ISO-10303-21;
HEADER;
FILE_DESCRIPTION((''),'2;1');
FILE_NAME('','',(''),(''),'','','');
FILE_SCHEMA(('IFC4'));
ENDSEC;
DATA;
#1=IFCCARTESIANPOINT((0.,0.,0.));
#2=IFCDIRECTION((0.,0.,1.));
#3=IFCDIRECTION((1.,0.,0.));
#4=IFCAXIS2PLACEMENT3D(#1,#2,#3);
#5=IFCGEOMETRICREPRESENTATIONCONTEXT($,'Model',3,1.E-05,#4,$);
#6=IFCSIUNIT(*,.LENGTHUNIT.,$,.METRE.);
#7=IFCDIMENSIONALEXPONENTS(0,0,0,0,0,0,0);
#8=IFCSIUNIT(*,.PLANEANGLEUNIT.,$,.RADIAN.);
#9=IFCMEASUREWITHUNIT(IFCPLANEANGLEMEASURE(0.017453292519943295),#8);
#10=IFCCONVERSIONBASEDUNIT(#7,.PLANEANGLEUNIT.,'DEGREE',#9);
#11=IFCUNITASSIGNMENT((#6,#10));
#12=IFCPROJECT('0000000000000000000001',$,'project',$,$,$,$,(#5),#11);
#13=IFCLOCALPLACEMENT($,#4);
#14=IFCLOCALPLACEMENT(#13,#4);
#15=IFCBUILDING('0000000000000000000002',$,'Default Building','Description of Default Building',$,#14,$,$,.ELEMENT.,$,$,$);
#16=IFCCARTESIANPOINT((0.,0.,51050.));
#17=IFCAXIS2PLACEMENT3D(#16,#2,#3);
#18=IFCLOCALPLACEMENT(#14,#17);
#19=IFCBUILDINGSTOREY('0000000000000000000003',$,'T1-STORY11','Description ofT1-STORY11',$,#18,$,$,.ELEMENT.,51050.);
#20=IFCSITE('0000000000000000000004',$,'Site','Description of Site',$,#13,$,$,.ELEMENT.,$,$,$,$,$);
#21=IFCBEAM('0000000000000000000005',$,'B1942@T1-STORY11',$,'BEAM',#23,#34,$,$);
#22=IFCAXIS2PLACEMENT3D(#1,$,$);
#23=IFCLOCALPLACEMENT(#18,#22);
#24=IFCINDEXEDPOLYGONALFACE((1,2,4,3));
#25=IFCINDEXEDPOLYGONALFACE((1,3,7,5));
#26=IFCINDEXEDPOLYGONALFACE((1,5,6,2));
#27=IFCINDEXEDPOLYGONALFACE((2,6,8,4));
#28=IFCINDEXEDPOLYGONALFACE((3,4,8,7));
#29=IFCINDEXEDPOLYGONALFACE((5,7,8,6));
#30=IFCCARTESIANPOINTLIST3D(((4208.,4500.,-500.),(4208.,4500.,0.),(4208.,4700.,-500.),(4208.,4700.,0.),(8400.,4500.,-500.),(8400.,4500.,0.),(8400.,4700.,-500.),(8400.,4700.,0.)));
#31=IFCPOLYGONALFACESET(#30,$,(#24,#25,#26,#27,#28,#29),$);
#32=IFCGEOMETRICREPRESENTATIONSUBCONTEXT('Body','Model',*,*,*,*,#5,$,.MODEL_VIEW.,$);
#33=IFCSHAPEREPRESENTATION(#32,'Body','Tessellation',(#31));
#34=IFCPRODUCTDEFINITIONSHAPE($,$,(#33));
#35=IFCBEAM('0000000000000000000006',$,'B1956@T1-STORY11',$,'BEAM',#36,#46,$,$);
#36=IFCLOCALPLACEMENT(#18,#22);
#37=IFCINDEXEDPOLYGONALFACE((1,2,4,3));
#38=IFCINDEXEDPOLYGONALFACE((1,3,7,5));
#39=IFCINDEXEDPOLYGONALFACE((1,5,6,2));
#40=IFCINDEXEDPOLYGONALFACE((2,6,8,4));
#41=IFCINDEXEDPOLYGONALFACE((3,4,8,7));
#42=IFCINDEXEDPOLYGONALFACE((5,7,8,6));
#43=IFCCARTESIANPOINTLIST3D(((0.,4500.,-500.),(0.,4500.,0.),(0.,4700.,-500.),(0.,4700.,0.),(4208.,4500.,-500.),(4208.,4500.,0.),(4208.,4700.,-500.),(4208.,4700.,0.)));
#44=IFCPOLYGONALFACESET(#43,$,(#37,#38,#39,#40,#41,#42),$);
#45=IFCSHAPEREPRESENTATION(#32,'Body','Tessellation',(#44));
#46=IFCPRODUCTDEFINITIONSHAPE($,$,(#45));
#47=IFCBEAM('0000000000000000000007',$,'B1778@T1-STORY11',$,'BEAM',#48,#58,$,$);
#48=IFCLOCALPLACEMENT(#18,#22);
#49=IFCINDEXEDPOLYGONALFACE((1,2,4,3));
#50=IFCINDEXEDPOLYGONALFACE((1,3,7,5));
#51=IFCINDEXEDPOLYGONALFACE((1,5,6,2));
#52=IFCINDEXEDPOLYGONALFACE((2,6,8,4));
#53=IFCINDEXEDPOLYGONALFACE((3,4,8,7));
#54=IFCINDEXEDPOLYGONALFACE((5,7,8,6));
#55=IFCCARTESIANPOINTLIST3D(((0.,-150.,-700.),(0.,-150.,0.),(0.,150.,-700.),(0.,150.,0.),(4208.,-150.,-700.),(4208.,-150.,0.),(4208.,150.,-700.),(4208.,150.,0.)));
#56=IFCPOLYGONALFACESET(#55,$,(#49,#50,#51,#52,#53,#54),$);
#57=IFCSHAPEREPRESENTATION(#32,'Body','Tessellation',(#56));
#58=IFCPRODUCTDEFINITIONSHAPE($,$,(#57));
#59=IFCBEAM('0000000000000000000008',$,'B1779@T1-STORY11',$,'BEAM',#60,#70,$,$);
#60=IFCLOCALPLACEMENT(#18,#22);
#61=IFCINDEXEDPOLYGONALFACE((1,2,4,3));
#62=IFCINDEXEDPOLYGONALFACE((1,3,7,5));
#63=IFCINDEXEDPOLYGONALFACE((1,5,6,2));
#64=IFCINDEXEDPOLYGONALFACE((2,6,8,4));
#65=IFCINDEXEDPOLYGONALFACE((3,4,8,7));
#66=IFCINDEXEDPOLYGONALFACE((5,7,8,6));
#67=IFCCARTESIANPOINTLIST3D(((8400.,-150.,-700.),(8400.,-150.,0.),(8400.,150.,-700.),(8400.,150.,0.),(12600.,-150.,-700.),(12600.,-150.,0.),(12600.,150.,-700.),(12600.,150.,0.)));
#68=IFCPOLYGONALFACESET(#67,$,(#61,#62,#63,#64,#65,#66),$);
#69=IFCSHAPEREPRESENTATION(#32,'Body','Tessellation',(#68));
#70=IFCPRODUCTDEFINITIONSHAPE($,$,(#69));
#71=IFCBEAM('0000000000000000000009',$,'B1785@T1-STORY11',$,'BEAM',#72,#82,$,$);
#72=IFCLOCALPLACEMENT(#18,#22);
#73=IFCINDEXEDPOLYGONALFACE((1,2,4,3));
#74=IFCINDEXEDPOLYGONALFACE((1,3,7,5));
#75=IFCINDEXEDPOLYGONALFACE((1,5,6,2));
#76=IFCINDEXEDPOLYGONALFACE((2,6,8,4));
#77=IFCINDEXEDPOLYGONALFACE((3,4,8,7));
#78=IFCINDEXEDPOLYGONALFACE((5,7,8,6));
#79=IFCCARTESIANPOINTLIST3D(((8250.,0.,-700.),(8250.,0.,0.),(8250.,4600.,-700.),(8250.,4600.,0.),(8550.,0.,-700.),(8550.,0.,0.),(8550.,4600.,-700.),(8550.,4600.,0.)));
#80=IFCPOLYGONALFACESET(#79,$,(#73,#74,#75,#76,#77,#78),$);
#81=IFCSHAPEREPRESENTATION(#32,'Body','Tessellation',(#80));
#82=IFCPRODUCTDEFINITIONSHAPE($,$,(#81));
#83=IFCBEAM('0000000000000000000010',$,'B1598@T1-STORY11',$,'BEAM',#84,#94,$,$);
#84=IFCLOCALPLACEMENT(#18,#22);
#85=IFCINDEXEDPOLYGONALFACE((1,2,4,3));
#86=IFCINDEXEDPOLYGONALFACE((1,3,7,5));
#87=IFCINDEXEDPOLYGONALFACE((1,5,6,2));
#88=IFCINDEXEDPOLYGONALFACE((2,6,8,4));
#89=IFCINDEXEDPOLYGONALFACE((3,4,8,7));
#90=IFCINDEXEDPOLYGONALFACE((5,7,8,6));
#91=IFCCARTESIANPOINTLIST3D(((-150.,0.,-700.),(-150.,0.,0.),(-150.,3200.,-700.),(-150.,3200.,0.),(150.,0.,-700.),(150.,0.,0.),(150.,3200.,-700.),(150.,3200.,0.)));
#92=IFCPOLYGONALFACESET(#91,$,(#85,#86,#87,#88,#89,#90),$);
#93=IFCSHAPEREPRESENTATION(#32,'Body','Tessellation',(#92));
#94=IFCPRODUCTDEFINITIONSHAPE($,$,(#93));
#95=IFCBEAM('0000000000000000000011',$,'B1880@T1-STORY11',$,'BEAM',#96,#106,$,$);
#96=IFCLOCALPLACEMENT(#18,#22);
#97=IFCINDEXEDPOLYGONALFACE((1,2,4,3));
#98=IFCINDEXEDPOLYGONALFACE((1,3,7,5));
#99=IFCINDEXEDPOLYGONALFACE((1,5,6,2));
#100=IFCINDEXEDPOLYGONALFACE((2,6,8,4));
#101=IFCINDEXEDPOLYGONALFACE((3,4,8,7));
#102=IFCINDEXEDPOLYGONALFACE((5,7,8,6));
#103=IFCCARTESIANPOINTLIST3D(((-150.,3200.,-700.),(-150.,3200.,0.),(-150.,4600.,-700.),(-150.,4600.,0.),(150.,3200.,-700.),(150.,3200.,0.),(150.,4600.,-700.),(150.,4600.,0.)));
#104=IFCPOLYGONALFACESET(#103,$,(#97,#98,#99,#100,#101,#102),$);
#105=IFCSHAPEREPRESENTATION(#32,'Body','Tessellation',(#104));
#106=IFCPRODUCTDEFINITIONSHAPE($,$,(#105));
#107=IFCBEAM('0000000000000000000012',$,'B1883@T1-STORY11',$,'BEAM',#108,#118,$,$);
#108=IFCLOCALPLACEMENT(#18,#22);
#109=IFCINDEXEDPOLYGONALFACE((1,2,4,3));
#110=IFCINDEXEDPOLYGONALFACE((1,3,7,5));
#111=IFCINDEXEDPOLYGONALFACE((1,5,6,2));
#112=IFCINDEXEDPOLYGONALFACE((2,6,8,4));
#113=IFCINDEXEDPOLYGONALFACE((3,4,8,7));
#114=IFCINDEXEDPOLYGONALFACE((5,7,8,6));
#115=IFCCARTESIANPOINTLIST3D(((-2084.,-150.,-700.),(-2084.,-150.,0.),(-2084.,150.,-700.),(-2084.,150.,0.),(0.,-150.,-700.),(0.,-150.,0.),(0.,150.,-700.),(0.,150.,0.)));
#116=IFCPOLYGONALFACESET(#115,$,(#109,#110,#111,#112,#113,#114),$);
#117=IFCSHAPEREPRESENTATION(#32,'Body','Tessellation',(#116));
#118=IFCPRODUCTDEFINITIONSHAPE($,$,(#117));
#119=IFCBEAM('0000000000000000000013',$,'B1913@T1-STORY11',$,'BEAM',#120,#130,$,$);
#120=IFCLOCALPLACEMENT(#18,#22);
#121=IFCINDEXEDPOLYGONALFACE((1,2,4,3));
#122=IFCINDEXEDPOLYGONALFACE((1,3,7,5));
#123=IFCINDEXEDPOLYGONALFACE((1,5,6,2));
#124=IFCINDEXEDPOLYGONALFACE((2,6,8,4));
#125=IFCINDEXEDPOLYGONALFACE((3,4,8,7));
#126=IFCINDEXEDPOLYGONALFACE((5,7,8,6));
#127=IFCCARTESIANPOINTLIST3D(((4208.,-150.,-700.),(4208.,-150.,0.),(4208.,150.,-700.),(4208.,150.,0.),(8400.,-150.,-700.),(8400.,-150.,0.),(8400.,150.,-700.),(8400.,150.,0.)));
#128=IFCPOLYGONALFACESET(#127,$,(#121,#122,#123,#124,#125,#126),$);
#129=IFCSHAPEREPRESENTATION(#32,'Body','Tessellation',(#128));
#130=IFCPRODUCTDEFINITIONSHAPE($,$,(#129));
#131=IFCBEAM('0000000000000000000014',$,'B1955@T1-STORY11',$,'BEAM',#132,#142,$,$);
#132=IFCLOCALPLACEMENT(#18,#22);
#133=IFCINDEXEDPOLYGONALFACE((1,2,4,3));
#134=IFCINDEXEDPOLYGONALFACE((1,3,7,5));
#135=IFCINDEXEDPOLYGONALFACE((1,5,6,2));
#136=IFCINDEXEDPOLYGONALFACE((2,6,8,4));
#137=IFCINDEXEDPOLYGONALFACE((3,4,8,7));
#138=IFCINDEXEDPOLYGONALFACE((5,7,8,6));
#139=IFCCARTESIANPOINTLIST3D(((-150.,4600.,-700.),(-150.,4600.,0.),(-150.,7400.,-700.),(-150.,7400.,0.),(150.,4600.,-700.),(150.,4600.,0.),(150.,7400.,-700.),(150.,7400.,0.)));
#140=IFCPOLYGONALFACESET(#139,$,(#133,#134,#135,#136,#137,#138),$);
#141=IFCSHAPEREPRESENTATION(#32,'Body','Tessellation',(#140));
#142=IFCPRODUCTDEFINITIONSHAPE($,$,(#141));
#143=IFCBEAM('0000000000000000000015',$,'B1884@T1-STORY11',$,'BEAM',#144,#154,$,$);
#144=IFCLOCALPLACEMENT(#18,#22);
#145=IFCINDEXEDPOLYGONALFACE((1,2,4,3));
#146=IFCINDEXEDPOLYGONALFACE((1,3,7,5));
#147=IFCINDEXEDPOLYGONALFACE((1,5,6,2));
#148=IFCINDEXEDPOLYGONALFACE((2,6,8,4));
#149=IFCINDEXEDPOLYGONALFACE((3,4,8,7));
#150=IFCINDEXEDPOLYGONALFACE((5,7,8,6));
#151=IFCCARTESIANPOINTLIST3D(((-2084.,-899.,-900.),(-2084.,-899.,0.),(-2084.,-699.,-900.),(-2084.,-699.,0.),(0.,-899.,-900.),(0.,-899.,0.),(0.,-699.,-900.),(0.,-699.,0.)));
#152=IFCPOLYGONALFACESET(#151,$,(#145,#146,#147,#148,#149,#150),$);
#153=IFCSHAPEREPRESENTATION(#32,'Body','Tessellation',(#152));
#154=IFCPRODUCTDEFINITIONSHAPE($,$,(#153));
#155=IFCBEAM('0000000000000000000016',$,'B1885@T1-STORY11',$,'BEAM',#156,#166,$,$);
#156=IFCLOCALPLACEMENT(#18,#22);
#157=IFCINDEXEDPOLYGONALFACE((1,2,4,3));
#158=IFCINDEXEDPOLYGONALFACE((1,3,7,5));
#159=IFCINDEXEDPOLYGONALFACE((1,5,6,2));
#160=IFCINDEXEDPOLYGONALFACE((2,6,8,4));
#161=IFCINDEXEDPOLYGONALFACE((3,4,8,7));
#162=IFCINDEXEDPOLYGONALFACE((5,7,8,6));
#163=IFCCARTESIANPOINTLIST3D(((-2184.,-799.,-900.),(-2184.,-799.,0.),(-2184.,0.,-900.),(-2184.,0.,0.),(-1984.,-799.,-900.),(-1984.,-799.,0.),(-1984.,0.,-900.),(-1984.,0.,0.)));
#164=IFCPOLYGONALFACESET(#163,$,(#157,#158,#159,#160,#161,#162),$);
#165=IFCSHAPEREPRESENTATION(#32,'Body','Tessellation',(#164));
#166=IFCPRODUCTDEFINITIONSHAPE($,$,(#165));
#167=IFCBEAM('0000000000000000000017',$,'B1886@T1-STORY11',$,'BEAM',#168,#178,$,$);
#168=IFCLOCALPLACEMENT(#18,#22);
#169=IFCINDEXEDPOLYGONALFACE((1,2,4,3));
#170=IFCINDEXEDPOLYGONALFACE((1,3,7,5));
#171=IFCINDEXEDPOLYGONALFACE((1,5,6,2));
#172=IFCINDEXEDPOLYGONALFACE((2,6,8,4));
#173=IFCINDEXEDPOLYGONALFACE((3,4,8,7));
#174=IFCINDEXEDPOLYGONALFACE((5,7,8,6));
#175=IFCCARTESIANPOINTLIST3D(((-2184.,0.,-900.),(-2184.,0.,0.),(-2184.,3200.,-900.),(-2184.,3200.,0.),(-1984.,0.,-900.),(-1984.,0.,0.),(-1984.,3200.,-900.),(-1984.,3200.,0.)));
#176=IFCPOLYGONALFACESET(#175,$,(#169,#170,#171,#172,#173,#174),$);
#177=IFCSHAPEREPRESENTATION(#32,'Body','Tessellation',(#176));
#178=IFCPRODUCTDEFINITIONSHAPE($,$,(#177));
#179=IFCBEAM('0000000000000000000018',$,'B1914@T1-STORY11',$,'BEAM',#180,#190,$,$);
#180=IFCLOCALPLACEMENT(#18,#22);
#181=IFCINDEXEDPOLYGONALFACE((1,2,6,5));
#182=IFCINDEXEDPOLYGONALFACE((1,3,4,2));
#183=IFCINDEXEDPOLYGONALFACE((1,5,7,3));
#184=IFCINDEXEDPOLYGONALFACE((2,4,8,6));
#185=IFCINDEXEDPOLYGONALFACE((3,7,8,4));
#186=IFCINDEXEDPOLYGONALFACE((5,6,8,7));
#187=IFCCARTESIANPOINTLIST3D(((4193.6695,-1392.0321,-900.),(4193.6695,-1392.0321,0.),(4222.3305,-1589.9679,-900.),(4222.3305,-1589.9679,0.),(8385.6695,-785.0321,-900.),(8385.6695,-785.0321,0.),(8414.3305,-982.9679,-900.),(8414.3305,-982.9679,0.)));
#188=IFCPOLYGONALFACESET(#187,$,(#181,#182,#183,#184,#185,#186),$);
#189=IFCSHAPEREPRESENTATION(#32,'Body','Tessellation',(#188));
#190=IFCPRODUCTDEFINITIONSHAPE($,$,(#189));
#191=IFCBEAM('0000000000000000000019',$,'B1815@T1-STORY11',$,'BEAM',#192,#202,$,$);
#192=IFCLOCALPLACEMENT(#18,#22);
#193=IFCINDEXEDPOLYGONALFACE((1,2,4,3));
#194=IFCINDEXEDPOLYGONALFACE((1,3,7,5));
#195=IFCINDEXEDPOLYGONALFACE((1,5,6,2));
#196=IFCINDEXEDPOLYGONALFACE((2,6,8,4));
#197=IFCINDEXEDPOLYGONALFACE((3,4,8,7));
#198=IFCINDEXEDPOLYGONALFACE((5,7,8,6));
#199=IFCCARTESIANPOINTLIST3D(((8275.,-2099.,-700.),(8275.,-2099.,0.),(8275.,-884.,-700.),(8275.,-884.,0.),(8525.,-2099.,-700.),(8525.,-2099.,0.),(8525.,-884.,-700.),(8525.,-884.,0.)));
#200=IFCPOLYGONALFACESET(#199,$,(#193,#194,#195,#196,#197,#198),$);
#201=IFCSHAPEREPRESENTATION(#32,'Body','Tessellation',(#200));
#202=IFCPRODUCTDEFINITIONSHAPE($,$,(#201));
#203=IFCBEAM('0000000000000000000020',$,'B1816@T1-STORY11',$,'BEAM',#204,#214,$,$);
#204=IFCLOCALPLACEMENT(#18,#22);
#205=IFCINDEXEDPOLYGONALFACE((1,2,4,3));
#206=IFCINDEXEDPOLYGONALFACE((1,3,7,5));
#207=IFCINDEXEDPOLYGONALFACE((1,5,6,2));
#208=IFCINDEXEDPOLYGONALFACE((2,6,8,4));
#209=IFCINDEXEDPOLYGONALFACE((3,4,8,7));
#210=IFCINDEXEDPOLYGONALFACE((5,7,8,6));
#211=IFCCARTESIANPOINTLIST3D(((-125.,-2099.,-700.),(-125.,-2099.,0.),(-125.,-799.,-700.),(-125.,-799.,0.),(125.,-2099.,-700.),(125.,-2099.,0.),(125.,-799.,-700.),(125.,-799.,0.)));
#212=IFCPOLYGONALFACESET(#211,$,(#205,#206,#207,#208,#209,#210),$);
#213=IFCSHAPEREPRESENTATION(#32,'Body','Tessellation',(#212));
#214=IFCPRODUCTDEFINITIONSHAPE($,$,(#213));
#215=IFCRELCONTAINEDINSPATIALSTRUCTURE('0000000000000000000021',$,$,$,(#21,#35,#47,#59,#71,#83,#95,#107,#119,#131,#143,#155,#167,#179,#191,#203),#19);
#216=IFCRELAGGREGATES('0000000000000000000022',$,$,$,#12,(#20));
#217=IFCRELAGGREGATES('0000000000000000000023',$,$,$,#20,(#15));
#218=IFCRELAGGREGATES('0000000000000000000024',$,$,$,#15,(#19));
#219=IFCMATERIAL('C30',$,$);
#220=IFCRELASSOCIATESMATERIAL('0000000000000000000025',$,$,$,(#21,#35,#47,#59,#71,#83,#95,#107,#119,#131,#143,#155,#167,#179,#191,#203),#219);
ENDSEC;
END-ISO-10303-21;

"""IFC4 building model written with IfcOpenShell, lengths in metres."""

from ifc_helpers import new_model, entity, si_unit, converted_unit, frame, origin_with_axes, place, context, subcontext, project, spatial, rectangle, extrude, material, element, save


model = new_model("IFC4")

# Units and contexts
model_context = context("Model", 3, precision=1e-05, world=origin_with_axes())
body_context = subcontext(model_context, "Body", "Model", "MODEL_VIEW")
ifc_project = project(units=[si_unit("LENGTHUNIT", "METRE"), converted_unit("PLANEANGLEUNIT", "DEGREE", entity("IfcPlaneAngleMeasure", 0.017453292519943295), si_unit("PLANEANGLEUNIT", "RADIAN"), dimensions=[0, 0, 0, 0, 0, 0, 0])], contexts=[model_context])

# Site, building, storey
site_placement = place(None, origin_with_axes())
site = spatial("IfcSite", under=ifc_project, at=site_placement, Name="Site", Description="Description of Site", CompositionType="ELEMENT")
building_placement = place(site_placement, origin_with_axes())
building = spatial("IfcBuilding", under=site, at=building_placement, Name="Default Building", Description="Description of Default Building", CompositionType="ELEMENT")
storey_placement = place(building_placement, frame((0.0, 0.0, 51050.0), z_axis=(0.0, 0.0, 1.0), x_axis=(1.0, 0.0, 0.0)))
storey = spatial("IfcBuildingStorey", under=building, at=storey_placement, Name="T1-STORY11", Description="Description ofT1-STORY11", CompositionType="ELEMENT", Elevation=51050.0)

# Beams
ifc_material_1 = material(Name="C30")
beam_1_placement = place(storey_placement, frame((4208.0, 4600.0, -250.0), z_axis=(1.0, 0.0, 0.0), x_axis=(0.0, 1.0, 0.0)))
element("IfcBeam", 1, at=beam_1_placement, inside=storey, material=ifc_material_1, Name="B1942@T1-STORY11", ObjectType="BEAM", context=body_context, shape_type="SweptSolid", body=[
    extrude(rectangle(XDim=200.0, YDim=500.0), origin_with_axes(), (0.0, 0.0, 1.0), 4192.0),
])
beam_2_placement = place(storey_placement, frame((0.0, 4600.0, -250.0), z_axis=(1.0, 0.0, 0.0), x_axis=(0.0, 1.0, 0.0)))
element("IfcBeam", 2, at=beam_2_placement, inside=storey, material=ifc_material_1, Name="B1956@T1-STORY11", ObjectType="BEAM", context=body_context, shape_type="SweptSolid", body=[
    extrude(rectangle(XDim=200.0, YDim=500.0), origin_with_axes(), (0.0, 0.0, 1.0), 4208.0),
])
beam_3_placement = place(storey_placement, frame((0.0, 0.0, -350.0), z_axis=(1.0, 0.0, 0.0), x_axis=(0.0, 1.0, 0.0)))
element("IfcBeam", 3, at=beam_3_placement, inside=storey, material=ifc_material_1, Name="B1778@T1-STORY11", ObjectType="BEAM", context=body_context, shape_type="SweptSolid", body=[
    extrude(rectangle(XDim=300.0, YDim=700.0), origin_with_axes(), (0.0, 0.0, 1.0), 4208.0),
])
beam_4_placement = place(storey_placement, frame((8400.0, 0.0, -350.0), z_axis=(1.0, 0.0, 0.0), x_axis=(0.0, 1.0, 0.0)))
element("IfcBeam", 4, at=beam_4_placement, inside=storey, material=ifc_material_1, Name="B1779@T1-STORY11", ObjectType="BEAM", context=body_context, shape_type="SweptSolid", body=[
    extrude(rectangle(XDim=300.0, YDim=700.0), origin_with_axes(), (0.0, 0.0, 1.0), 4200.0),
])
beam_5_placement = place(storey_placement, frame((8400.0, 0.0, -350.0), z_axis=(0.0, 1.0, 0.0), x_axis=(-1.0, 0.0, 0.0)))
element("IfcBeam", 5, at=beam_5_placement, inside=storey, material=ifc_material_1, Name="B1785@T1-STORY11", ObjectType="BEAM", context=body_context, shape_type="SweptSolid", body=[
    extrude(rectangle(XDim=300.0, YDim=700.0), origin_with_axes(), (0.0, 0.0, 1.0), 4600.0),
])
beam_6_placement = place(storey_placement, frame((0.0, 0.0, -350.0), z_axis=(0.0, 1.0, 0.0), x_axis=(-1.0, 0.0, 0.0)))
element("IfcBeam", 6, at=beam_6_placement, inside=storey, material=ifc_material_1, Name="B1598@T1-STORY11", ObjectType="BEAM", context=body_context, shape_type="SweptSolid", body=[
    extrude(rectangle(XDim=300.0, YDim=700.0), origin_with_axes(), (0.0, 0.0, 1.0), 3200.0),
])
beam_7_placement = place(storey_placement, frame((0.0, 3200.0, -350.0), z_axis=(0.0, 1.0, 0.0), x_axis=(-1.0, 0.0, 0.0)))
element("IfcBeam", 7, at=beam_7_placement, inside=storey, material=ifc_material_1, Name="B1880@T1-STORY11", ObjectType="BEAM", context=body_context, shape_type="SweptSolid", body=[
    extrude(rectangle(XDim=300.0, YDim=700.0), origin_with_axes(), (0.0, 0.0, 1.0), 1400.0),
])
beam_8_placement = place(storey_placement, frame((-2084.0, 0.0, -350.0), z_axis=(1.0, 0.0, 0.0), x_axis=(0.0, 1.0, 0.0)))
element("IfcBeam", 8, at=beam_8_placement, inside=storey, material=ifc_material_1, Name="B1883@T1-STORY11", ObjectType="BEAM", context=body_context, shape_type="SweptSolid", body=[
    extrude(rectangle(XDim=300.0, YDim=700.0), origin_with_axes(), (0.0, 0.0, 1.0), 2084.0),
])
beam_9_placement = place(storey_placement, frame((4208.0, 0.0, -350.0), z_axis=(1.0, 0.0, 0.0), x_axis=(0.0, 1.0, 0.0)))
element("IfcBeam", 9, at=beam_9_placement, inside=storey, material=ifc_material_1, Name="B1913@T1-STORY11", ObjectType="BEAM", context=body_context, shape_type="SweptSolid", body=[
    extrude(rectangle(XDim=300.0, YDim=700.0), origin_with_axes(), (0.0, 0.0, 1.0), 4192.0),
])
beam_10_placement = place(storey_placement, frame((0.0, 4600.0, -350.0), z_axis=(0.0, 1.0, 0.0), x_axis=(-1.0, 0.0, 0.0)))
element("IfcBeam", 10, at=beam_10_placement, inside=storey, material=ifc_material_1, Name="B1955@T1-STORY11", ObjectType="BEAM", context=body_context, shape_type="SweptSolid", body=[
    extrude(rectangle(XDim=300.0, YDim=700.0), origin_with_axes(), (0.0, 0.0, 1.0), 2800.0),
])
beam_11_placement = place(storey_placement, frame((-2084.0, -799.0, -450.0), z_axis=(1.0, 0.0, 0.0), x_axis=(0.0, 1.0, 0.0)))
element("IfcBeam", 11, at=beam_11_placement, inside=storey, material=ifc_material_1, Name="B1884@T1-STORY11", ObjectType="BEAM", context=body_context, shape_type="SweptSolid", body=[
    extrude(rectangle(XDim=200.0, YDim=900.0), origin_with_axes(), (0.0, 0.0, 1.0), 2084.0),
])
beam_12_placement = place(storey_placement, frame((-2084.0, -799.0, -450.0), z_axis=(0.0, 1.0, 0.0), x_axis=(-1.0, 0.0, 0.0)))
element("IfcBeam", 12, at=beam_12_placement, inside=storey, material=ifc_material_1, Name="B1885@T1-STORY11", ObjectType="BEAM", context=body_context, shape_type="SweptSolid", body=[
    extrude(rectangle(XDim=200.0, YDim=900.0), origin_with_axes(), (0.0, 0.0, 1.0), 799.0),
])
beam_13_placement = place(storey_placement, frame((-2084.0, 0.0, -450.0), z_axis=(0.0, 1.0, 0.0), x_axis=(-1.0, 0.0, 0.0)))
element("IfcBeam", 13, at=beam_13_placement, inside=storey, material=ifc_material_1, Name="B1886@T1-STORY11", ObjectType="BEAM", context=body_context, shape_type="SweptSolid", body=[
    extrude(rectangle(XDim=200.0, YDim=900.0), origin_with_axes(), (0.0, 0.0, 1.0), 3200.0),
])
beam_14_placement = place(storey_placement, frame((4208.0, -1491.0, -450.0), z_axis=(0.989679, 0.143305, 0.0), x_axis=(-0.143305, 0.989679, 0.0)))
element("IfcBeam", 14, at=beam_14_placement, inside=storey, material=ifc_material_1, Name="B1914@T1-STORY11", ObjectType="BEAM", context=body_context, shape_type="SweptSolid", body=[
    extrude(rectangle(XDim=200.0, YDim=900.0), origin_with_axes(), (0.0, 0.0, 1.0), 4235.7187),
])
beam_15_placement = place(storey_placement, frame((8400.0, -2099.0, -350.0), z_axis=(0.0, 1.0, 0.0), x_axis=(-1.0, 0.0, 0.0)))
element("IfcBeam", 15, at=beam_15_placement, inside=storey, material=ifc_material_1, Name="B1815@T1-STORY11", ObjectType="BEAM", context=body_context, shape_type="SweptSolid", body=[
    extrude(rectangle(XDim=250.0, YDim=700.0), origin_with_axes(), (0.0, 0.0, 1.0), 1215.0),
])
beam_16_placement = place(storey_placement, frame((0.0, -2099.0, -350.0), z_axis=(0.0, 1.0, 0.0), x_axis=(-1.0, 0.0, 0.0)))
element("IfcBeam", 16, at=beam_16_placement, inside=storey, material=ifc_material_1, Name="B1816@T1-STORY11", ObjectType="BEAM", context=body_context, shape_type="SweptSolid", body=[
    extrude(rectangle(XDim=250.0, YDim=700.0), origin_with_axes(), (0.0, 0.0, 1.0), 1300.0),
])

save(model, "model.ifc")
